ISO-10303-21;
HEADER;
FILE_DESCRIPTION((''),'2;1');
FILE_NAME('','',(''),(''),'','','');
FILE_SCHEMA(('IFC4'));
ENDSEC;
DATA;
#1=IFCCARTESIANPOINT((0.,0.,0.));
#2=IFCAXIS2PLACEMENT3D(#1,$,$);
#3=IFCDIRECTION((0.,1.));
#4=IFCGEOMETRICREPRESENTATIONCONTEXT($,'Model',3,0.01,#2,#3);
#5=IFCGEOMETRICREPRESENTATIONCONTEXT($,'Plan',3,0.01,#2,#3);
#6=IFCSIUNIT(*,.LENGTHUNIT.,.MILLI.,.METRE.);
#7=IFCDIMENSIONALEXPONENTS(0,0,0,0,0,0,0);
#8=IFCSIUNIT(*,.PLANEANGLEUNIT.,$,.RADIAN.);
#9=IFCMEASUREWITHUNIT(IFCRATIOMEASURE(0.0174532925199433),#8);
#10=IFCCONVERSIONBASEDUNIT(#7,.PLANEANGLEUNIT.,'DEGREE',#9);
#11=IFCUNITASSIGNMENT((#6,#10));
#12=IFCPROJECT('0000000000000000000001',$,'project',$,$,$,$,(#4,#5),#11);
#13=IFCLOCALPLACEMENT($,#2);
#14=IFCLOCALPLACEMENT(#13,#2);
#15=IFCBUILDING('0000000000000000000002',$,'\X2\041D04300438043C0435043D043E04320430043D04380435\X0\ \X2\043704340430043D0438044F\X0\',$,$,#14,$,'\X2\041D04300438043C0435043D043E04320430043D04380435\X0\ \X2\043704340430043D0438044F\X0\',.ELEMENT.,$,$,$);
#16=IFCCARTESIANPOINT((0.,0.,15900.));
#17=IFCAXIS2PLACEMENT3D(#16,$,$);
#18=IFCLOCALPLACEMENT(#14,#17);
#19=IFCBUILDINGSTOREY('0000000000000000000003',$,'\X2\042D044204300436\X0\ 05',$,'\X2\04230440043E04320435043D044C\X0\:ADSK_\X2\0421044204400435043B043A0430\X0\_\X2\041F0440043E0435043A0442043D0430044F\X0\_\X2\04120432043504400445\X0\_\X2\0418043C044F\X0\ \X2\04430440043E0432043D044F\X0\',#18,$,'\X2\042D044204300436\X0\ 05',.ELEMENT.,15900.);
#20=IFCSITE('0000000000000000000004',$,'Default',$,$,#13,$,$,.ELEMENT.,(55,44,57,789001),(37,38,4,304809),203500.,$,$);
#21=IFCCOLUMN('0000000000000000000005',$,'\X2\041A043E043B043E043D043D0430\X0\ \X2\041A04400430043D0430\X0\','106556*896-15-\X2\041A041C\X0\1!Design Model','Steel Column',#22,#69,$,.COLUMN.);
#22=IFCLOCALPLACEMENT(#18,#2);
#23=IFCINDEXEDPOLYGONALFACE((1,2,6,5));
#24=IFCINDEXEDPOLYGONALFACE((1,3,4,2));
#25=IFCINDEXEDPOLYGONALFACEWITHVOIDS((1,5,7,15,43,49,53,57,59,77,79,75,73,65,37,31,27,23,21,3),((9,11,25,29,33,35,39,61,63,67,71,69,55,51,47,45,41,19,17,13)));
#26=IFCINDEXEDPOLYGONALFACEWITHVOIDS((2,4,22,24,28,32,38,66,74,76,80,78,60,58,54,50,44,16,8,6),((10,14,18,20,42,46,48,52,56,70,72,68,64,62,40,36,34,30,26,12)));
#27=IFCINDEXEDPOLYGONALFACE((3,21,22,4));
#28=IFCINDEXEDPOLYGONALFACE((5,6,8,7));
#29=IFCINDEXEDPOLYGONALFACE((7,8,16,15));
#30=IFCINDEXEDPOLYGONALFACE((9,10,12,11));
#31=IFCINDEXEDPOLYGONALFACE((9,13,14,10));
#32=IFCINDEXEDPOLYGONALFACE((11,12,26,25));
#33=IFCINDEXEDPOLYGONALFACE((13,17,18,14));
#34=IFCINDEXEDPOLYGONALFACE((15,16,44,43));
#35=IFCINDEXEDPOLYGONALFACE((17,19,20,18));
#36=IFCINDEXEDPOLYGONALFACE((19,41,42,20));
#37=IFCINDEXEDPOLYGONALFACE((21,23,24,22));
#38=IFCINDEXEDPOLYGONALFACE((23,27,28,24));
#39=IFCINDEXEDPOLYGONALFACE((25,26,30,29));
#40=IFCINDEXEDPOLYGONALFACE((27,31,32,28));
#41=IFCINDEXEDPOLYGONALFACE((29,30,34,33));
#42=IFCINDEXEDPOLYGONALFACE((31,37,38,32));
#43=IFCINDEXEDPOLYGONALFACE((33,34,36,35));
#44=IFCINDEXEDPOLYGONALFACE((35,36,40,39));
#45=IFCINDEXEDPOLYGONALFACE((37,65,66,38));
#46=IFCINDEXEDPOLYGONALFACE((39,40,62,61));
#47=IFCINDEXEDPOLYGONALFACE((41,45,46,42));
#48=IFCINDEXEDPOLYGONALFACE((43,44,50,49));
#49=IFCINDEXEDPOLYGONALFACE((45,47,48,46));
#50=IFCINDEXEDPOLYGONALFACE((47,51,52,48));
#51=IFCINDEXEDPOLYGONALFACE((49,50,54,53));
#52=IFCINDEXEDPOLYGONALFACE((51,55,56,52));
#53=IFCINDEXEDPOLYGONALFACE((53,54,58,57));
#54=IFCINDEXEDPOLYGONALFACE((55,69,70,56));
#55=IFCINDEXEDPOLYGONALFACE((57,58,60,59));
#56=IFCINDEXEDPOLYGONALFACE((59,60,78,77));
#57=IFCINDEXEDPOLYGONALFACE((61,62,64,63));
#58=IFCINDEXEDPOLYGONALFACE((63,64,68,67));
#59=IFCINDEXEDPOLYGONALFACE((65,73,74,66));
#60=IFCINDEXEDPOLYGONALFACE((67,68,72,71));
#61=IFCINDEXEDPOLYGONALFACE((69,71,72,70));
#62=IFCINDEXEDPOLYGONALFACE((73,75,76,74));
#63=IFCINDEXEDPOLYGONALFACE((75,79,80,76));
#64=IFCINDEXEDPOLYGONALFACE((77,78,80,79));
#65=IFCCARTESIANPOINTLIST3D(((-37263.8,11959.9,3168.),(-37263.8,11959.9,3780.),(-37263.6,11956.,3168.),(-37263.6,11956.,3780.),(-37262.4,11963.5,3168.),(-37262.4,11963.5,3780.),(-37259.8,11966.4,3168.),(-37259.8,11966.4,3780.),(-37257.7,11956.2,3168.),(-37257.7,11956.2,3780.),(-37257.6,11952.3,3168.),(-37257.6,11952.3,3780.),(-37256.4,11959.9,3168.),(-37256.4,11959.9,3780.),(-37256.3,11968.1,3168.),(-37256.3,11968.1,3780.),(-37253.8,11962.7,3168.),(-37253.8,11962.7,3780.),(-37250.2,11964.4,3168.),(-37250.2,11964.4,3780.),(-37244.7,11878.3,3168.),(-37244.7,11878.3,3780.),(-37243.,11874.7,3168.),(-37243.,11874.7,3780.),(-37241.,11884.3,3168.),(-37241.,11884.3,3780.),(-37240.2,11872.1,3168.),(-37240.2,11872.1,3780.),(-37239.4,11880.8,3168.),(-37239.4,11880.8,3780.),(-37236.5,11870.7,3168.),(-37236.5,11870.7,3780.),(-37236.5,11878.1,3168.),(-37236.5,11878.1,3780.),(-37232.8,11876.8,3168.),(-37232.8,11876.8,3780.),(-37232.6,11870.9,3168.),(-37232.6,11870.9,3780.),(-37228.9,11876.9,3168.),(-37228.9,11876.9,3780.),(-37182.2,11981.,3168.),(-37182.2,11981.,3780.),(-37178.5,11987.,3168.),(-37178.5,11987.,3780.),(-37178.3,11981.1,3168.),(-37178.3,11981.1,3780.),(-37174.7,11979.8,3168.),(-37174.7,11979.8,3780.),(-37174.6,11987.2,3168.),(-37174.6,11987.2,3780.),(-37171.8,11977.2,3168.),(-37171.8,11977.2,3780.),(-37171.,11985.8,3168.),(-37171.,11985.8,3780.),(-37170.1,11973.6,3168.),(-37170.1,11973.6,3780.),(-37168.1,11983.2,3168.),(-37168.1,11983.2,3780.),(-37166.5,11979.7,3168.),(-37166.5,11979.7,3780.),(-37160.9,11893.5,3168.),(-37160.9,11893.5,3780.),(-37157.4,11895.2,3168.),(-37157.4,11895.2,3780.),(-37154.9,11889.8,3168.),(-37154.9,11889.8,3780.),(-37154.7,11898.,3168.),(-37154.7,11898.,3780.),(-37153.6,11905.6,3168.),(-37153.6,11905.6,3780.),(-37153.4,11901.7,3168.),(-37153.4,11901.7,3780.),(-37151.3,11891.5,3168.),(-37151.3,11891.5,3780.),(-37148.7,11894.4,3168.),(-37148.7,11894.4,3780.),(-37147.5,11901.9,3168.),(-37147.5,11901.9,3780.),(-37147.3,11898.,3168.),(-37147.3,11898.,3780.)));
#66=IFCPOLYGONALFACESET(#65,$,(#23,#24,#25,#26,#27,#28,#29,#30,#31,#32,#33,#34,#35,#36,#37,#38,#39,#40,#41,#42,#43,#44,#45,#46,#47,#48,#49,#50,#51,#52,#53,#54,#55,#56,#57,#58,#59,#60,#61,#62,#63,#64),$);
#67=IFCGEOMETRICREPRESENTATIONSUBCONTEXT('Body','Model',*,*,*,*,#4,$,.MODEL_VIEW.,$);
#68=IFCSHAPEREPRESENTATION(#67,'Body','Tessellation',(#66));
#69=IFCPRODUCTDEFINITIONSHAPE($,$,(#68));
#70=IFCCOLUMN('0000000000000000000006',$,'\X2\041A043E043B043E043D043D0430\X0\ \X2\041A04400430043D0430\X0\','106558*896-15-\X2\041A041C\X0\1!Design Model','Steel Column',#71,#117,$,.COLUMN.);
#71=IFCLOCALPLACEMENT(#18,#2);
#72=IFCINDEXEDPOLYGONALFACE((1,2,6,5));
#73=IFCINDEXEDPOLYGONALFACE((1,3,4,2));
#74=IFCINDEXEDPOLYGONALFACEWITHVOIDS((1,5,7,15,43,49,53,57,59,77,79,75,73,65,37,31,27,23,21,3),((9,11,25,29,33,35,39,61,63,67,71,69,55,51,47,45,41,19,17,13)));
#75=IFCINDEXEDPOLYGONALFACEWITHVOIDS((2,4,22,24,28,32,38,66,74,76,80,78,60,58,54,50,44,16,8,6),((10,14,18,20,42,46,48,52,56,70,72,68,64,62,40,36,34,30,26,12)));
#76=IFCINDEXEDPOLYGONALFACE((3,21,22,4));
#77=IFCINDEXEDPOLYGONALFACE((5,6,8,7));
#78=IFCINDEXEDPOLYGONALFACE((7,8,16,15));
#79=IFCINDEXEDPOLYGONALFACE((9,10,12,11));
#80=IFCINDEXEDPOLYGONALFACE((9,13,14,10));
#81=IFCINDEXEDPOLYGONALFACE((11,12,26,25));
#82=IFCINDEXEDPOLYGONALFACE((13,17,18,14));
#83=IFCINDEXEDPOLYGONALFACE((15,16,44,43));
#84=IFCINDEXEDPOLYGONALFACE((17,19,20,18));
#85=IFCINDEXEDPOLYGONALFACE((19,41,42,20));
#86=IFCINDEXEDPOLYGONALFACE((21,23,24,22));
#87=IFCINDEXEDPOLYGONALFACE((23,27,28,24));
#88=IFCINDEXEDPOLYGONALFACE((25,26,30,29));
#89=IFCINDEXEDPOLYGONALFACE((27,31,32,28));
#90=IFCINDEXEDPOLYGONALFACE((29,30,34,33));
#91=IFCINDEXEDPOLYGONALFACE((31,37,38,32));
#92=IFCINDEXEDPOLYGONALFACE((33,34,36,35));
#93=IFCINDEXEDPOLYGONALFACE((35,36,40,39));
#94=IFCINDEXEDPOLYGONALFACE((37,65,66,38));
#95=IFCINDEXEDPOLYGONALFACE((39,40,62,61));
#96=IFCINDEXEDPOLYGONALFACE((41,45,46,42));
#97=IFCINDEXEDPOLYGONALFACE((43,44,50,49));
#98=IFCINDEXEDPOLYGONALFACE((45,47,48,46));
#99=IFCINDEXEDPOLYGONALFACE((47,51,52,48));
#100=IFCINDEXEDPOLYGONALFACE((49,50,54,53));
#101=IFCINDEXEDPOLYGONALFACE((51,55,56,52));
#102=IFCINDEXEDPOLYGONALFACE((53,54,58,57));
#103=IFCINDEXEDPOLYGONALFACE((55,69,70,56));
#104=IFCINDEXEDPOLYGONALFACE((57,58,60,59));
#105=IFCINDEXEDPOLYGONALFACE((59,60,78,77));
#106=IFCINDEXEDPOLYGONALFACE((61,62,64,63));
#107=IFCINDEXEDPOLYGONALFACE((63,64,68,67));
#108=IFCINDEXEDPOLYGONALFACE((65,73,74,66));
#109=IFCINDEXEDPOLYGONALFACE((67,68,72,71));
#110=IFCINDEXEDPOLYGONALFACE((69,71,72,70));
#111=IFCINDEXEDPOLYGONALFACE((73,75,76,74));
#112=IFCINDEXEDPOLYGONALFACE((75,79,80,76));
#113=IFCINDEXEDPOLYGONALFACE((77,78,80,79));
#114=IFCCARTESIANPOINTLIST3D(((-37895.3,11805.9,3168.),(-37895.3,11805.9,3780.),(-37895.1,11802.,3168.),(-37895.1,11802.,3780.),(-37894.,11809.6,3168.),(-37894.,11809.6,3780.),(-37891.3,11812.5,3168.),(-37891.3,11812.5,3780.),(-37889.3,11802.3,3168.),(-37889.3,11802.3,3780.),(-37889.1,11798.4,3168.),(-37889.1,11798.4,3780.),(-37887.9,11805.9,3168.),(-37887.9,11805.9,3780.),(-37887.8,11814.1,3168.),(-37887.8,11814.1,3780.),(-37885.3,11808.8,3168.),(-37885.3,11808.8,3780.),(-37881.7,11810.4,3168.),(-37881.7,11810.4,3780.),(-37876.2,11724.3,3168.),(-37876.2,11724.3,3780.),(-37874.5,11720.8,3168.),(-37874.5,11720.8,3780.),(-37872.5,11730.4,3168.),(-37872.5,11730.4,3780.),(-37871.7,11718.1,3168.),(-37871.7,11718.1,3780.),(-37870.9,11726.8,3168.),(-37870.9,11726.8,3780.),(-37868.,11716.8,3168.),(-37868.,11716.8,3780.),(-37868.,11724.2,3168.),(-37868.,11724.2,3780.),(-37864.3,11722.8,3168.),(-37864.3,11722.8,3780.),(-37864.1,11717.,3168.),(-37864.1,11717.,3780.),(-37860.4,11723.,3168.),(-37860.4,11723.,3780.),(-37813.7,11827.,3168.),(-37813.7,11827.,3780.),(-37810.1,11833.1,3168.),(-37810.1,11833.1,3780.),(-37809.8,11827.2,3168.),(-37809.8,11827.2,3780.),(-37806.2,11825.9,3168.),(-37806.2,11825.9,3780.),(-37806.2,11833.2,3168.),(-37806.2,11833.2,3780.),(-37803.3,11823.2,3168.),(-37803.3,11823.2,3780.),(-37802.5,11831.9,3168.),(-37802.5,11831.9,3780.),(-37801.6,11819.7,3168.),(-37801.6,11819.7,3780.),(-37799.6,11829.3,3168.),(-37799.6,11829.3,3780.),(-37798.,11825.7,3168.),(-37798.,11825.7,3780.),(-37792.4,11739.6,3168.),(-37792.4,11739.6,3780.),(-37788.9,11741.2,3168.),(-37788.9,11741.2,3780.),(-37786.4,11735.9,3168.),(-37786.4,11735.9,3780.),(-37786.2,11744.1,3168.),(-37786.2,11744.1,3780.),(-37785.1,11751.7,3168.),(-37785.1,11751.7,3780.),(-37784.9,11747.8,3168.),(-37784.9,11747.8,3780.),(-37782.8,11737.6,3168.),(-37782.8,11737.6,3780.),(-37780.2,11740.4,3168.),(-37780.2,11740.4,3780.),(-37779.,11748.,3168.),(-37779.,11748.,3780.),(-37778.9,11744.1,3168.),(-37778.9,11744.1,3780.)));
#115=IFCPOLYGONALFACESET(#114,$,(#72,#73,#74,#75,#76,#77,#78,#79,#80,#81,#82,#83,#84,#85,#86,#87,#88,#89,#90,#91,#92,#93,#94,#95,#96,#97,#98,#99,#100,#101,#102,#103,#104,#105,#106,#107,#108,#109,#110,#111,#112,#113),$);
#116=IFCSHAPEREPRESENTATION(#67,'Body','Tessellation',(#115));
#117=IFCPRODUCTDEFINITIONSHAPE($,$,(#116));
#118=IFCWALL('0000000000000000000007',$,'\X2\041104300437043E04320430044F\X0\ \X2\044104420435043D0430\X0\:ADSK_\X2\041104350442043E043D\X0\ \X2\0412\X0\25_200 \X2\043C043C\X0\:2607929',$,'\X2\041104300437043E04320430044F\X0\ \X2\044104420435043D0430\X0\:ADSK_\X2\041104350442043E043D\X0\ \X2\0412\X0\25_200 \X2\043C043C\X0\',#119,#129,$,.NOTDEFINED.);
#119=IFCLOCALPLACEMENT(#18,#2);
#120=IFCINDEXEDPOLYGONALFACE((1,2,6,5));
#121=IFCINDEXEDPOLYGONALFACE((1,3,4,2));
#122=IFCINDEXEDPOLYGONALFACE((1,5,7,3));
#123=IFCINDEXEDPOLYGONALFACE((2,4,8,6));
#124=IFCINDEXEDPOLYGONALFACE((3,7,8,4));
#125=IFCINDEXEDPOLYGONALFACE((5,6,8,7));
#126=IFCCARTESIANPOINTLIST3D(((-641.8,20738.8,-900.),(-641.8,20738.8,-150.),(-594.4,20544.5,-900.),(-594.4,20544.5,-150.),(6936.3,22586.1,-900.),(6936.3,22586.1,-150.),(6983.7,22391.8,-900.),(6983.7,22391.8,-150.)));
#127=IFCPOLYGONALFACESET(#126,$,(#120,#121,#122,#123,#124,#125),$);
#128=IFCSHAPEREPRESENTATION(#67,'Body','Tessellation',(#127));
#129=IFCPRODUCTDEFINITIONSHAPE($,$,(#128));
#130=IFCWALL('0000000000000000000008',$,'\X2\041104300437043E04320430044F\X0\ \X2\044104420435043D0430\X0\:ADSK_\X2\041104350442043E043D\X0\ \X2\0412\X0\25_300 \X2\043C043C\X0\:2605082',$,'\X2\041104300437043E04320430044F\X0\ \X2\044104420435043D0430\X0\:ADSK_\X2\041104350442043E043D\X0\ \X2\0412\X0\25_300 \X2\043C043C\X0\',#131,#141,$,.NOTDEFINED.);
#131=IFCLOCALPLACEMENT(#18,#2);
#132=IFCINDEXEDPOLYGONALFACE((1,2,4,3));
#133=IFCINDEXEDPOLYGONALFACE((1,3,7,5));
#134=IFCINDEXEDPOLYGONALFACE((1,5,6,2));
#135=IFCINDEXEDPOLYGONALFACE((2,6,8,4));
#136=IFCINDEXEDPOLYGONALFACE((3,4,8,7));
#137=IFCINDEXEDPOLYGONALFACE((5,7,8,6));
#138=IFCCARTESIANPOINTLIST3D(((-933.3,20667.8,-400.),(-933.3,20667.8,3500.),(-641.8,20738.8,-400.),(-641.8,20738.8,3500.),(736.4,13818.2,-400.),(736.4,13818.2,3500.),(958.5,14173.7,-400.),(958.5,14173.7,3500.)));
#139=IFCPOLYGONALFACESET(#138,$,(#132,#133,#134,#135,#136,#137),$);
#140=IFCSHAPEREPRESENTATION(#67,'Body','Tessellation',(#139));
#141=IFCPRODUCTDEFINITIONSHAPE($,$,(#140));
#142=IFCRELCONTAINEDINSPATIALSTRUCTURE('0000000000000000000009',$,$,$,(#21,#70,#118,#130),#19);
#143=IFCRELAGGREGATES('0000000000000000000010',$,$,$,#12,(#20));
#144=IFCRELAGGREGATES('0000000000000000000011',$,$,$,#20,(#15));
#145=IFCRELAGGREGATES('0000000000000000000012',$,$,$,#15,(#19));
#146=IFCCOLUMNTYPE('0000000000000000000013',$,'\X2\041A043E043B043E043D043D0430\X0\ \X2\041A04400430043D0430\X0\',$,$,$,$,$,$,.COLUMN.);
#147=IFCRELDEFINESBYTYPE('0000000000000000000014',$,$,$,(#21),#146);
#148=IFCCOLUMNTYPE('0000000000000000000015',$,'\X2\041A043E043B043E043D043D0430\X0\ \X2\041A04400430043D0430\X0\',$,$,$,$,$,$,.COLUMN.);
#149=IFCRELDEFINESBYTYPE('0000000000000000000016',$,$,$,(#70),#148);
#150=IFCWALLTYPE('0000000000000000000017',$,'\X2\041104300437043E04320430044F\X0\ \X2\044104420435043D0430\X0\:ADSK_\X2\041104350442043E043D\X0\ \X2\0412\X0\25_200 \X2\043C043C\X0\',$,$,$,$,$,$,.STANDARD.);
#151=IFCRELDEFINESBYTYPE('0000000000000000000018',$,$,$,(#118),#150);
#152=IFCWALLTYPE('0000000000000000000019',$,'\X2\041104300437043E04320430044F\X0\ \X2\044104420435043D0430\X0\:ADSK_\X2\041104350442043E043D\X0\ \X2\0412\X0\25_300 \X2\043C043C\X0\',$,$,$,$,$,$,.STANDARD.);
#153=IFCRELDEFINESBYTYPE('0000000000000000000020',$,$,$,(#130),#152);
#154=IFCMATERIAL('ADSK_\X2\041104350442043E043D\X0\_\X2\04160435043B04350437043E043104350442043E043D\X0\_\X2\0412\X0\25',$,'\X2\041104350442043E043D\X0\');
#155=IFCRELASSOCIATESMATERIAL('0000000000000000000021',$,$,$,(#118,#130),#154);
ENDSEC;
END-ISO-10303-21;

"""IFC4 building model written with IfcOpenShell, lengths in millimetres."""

from ifc_helpers import new_model, entity, si_unit, converted_unit, direction, frame, origin, place, context, subcontext, project, spatial, indexed_curve, outline, extrude, material, type_object, element, save


model = new_model("IFC4")

# Units and contexts
model_context = context("Model", 3, precision=0.01, world=origin(), true_north=direction((0.0, 1.0)))
plan_context = context("Plan", 3, precision=0.01, world=origin(), true_north=direction((0.0, 1.0)))
body_context = subcontext(model_context, "Body", "Model", "MODEL_VIEW")
ifc_project = project(units=[si_unit("LENGTHUNIT", "METRE", prefix="MILLI"), converted_unit("PLANEANGLEUNIT", "DEGREE", entity("IfcRatioMeasure", 0.0174532925199433), si_unit("PLANEANGLEUNIT", "RADIAN"), dimensions=[0, 0, 0, 0, 0, 0, 0])], contexts=[model_context, plan_context])

# Site, building, storey
site_placement = place(None, origin())
site = spatial("IfcSite", under=ifc_project, at=site_placement, Name="Default", CompositionType="ELEMENT", RefLatitude=(55, 44, 57, 789001), RefLongitude=(37, 38, 4, 304809), RefElevation=203500.0)
building_placement = place(site_placement, origin())
building = spatial("IfcBuilding", under=site, at=building_placement, Name="Наименование здания", LongName="Наименование здания", CompositionType="ELEMENT")
storey_placement = place(building_placement, frame((0.0, 0.0, 15900.0)))
storey = spatial("IfcBuildingStorey", under=building, at=storey_placement, Name="Этаж 05", ObjectType="Уровень:ADSK_Стрелка_Проектная_Вверх_Имя уровня", LongName="Этаж 05", CompositionType="ELEMENT", Elevation=15900.0)

# Columns
column_type_1 = type_object("IfcColumnType", Name="Колонна Крана", PredefinedType="COLUMN")
column_1_placement = place(storey_placement, origin())
element("IfcColumn", 1, at=column_1_placement, inside=storey, type_object=column_type_1, Name="Колонна Крана", Description="106556*896-15-КМ1!Design Model", ObjectType="Steel Column", PredefinedType="COLUMN", context=body_context, shape_type="SweptSolid", body=[
    extrude(outline(indexed_curve([(29.5, -56.8), (33.4, -56.8), (37.0, -55.3), (39.7, -52.6), (41.2, -49.0), (56.8, 29.5), (56.8, 33.4), (55.3, 37.0), (52.6, 39.7), (49.0, 41.2), (-29.5, 56.8), (-33.4, 56.8), (-37.0, 55.3), (-39.7, 52.6), (-41.2, 49.0), (-56.8, -29.5), (-56.8, -33.4), (-55.3, -37.0), (-52.6, -39.7), (-49.0, -41.2), (29.5, -56.8)], self_intersect=False), holes=[indexed_curve([(-43.1, -37.3), (-46.7, -35.8), (-49.5, -33.1), (-51.0, -29.5), (-51.0, -25.5), (-37.3, 43.1), (-35.8, 46.7), (-33.1, 49.5), (-29.5, 51.0), (-25.5, 51.0), (43.1, 37.3), (46.7, 35.8), (49.5, 33.1), (51.0, 29.5), (51.0, 25.5), (37.3, -43.1), (35.8, -46.7), (33.1, -49.5), (29.5, -51.0), (25.5, -51.0), (-43.1, -37.3)], self_intersect=False)]), frame((-37205.6, 11929.0, 3168.0), z_axis=(0.0, 0.0, 1.0), x_axis=(0.906681, 0.421816, 0.0)), (0.0, 0.0, 1.0), 612.0),
])
column_type_2 = type_object("IfcColumnType", Name="Колонна Крана", PredefinedType="COLUMN")
column_2_placement = place(storey_placement, origin())
element("IfcColumn", 2, at=column_2_placement, inside=storey, type_object=column_type_2, Name="Колонна Крана", Description="106558*896-15-КМ1!Design Model", ObjectType="Steel Column", PredefinedType="COLUMN", context=body_context, shape_type="SweptSolid", body=[
    extrude(outline(indexed_curve([(29.5, -56.8), (33.4, -56.8), (37.0, -55.3), (39.7, -52.6), (41.2, -49.0), (56.8, 29.5), (56.8, 33.4), (55.3, 37.0), (52.6, 39.7), (49.0, 41.2), (-29.5, 56.8), (-33.4, 56.8), (-37.0, 55.3), (-39.7, 52.6), (-41.2, 49.0), (-56.8, -29.5), (-56.8, -33.4), (-55.3, -37.0), (-52.6, -39.7), (-49.0, -41.2), (29.5, -56.8)], self_intersect=False), holes=[indexed_curve([(-43.1, -37.3), (-46.7, -35.8), (-49.5, -33.1), (-51.0, -29.5), (-51.0, -25.5), (-37.3, 43.1), (-35.8, 46.7), (-33.1, 49.5), (-29.5, 51.0), (-25.5, 51.0), (43.1, 37.3), (46.7, 35.8), (49.5, 33.1), (51.0, 29.5), (51.0, 25.5), (37.3, -43.1), (35.8, -46.7), (33.1, -49.5), (29.5, -51.0), (25.5, -51.0), (-43.1, -37.3)], self_intersect=False)]), frame((-37837.1, 11775.0, 3168.0), z_axis=(0.0, 0.0, 1.0), x_axis=(0.906681, 0.421816, 0.0)), (0.0, 0.0, 1.0), 612.0),
])

# Walls
ifc_material = material(Name="ADSK_Бетон_Железобетон_В25", Category="Бетон")
wall_type_1 = type_object("IfcWallType", Name="Базовая стена:ADSK_Бетон В25_200 мм", PredefinedType="STANDARD")
wall_1_placement = place(storey_placement, frame((-618.1, 20641.7, -900.0), z_axis=(0.0, 0.0, 1.0), x_axis=(0.971552, 0.236826, 0.0)))
element("IfcWall", 3, at=wall_1_placement, inside=storey, type_object=wall_type_1, material=ifc_material, Name="Базовая стена:ADSK_Бетон В25_200 мм:2607929", ObjectType="Базовая стена:ADSK_Бетон В25_200 мм", PredefinedType="NOTDEFINED", context=body_context, shape_type="SweptSolid", body=[
    extrude(outline(indexed_curve([(7800.0, 100.0), (0.0, 100.0), (0.0, -100.0), (7800.0, -100.0), (7800.0, 100.0)], self_intersect=False)), origin(), (0.0, 0.0, 1.0), 750.0),
])
wall_type_2 = type_object("IfcWallType", Name="Базовая стена:ADSK_Бетон В25_300 мм", PredefinedType="STANDARD")
wall_2_placement = place(storey_placement, frame((-787.5, 20703.3, -400.0), z_axis=(0.0, 0.0, 1.0), x_axis=(0.236826, -0.971552, 0.0)))
element("IfcWall", 4, at=wall_2_placement, inside=storey, type_object=wall_type_2, material=ifc_material, Name="Базовая стена:ADSK_Бетон В25_300 мм:2605082", ObjectType="Базовая стена:ADSK_Бетон В25_300 мм", PredefinedType="NOTDEFINED", context=body_context, shape_type="SweptSolid", body=[
    extrude(outline(indexed_curve([(7050.2, -150.0), (6757.4, 150.0), (0.0, 150.0), (0.0, -150.0), (7050.2, -150.0)], self_intersect=False)), origin(), (0.0, 0.0, 1.0), 3900.0),
])

save(model, "model.ifc")
